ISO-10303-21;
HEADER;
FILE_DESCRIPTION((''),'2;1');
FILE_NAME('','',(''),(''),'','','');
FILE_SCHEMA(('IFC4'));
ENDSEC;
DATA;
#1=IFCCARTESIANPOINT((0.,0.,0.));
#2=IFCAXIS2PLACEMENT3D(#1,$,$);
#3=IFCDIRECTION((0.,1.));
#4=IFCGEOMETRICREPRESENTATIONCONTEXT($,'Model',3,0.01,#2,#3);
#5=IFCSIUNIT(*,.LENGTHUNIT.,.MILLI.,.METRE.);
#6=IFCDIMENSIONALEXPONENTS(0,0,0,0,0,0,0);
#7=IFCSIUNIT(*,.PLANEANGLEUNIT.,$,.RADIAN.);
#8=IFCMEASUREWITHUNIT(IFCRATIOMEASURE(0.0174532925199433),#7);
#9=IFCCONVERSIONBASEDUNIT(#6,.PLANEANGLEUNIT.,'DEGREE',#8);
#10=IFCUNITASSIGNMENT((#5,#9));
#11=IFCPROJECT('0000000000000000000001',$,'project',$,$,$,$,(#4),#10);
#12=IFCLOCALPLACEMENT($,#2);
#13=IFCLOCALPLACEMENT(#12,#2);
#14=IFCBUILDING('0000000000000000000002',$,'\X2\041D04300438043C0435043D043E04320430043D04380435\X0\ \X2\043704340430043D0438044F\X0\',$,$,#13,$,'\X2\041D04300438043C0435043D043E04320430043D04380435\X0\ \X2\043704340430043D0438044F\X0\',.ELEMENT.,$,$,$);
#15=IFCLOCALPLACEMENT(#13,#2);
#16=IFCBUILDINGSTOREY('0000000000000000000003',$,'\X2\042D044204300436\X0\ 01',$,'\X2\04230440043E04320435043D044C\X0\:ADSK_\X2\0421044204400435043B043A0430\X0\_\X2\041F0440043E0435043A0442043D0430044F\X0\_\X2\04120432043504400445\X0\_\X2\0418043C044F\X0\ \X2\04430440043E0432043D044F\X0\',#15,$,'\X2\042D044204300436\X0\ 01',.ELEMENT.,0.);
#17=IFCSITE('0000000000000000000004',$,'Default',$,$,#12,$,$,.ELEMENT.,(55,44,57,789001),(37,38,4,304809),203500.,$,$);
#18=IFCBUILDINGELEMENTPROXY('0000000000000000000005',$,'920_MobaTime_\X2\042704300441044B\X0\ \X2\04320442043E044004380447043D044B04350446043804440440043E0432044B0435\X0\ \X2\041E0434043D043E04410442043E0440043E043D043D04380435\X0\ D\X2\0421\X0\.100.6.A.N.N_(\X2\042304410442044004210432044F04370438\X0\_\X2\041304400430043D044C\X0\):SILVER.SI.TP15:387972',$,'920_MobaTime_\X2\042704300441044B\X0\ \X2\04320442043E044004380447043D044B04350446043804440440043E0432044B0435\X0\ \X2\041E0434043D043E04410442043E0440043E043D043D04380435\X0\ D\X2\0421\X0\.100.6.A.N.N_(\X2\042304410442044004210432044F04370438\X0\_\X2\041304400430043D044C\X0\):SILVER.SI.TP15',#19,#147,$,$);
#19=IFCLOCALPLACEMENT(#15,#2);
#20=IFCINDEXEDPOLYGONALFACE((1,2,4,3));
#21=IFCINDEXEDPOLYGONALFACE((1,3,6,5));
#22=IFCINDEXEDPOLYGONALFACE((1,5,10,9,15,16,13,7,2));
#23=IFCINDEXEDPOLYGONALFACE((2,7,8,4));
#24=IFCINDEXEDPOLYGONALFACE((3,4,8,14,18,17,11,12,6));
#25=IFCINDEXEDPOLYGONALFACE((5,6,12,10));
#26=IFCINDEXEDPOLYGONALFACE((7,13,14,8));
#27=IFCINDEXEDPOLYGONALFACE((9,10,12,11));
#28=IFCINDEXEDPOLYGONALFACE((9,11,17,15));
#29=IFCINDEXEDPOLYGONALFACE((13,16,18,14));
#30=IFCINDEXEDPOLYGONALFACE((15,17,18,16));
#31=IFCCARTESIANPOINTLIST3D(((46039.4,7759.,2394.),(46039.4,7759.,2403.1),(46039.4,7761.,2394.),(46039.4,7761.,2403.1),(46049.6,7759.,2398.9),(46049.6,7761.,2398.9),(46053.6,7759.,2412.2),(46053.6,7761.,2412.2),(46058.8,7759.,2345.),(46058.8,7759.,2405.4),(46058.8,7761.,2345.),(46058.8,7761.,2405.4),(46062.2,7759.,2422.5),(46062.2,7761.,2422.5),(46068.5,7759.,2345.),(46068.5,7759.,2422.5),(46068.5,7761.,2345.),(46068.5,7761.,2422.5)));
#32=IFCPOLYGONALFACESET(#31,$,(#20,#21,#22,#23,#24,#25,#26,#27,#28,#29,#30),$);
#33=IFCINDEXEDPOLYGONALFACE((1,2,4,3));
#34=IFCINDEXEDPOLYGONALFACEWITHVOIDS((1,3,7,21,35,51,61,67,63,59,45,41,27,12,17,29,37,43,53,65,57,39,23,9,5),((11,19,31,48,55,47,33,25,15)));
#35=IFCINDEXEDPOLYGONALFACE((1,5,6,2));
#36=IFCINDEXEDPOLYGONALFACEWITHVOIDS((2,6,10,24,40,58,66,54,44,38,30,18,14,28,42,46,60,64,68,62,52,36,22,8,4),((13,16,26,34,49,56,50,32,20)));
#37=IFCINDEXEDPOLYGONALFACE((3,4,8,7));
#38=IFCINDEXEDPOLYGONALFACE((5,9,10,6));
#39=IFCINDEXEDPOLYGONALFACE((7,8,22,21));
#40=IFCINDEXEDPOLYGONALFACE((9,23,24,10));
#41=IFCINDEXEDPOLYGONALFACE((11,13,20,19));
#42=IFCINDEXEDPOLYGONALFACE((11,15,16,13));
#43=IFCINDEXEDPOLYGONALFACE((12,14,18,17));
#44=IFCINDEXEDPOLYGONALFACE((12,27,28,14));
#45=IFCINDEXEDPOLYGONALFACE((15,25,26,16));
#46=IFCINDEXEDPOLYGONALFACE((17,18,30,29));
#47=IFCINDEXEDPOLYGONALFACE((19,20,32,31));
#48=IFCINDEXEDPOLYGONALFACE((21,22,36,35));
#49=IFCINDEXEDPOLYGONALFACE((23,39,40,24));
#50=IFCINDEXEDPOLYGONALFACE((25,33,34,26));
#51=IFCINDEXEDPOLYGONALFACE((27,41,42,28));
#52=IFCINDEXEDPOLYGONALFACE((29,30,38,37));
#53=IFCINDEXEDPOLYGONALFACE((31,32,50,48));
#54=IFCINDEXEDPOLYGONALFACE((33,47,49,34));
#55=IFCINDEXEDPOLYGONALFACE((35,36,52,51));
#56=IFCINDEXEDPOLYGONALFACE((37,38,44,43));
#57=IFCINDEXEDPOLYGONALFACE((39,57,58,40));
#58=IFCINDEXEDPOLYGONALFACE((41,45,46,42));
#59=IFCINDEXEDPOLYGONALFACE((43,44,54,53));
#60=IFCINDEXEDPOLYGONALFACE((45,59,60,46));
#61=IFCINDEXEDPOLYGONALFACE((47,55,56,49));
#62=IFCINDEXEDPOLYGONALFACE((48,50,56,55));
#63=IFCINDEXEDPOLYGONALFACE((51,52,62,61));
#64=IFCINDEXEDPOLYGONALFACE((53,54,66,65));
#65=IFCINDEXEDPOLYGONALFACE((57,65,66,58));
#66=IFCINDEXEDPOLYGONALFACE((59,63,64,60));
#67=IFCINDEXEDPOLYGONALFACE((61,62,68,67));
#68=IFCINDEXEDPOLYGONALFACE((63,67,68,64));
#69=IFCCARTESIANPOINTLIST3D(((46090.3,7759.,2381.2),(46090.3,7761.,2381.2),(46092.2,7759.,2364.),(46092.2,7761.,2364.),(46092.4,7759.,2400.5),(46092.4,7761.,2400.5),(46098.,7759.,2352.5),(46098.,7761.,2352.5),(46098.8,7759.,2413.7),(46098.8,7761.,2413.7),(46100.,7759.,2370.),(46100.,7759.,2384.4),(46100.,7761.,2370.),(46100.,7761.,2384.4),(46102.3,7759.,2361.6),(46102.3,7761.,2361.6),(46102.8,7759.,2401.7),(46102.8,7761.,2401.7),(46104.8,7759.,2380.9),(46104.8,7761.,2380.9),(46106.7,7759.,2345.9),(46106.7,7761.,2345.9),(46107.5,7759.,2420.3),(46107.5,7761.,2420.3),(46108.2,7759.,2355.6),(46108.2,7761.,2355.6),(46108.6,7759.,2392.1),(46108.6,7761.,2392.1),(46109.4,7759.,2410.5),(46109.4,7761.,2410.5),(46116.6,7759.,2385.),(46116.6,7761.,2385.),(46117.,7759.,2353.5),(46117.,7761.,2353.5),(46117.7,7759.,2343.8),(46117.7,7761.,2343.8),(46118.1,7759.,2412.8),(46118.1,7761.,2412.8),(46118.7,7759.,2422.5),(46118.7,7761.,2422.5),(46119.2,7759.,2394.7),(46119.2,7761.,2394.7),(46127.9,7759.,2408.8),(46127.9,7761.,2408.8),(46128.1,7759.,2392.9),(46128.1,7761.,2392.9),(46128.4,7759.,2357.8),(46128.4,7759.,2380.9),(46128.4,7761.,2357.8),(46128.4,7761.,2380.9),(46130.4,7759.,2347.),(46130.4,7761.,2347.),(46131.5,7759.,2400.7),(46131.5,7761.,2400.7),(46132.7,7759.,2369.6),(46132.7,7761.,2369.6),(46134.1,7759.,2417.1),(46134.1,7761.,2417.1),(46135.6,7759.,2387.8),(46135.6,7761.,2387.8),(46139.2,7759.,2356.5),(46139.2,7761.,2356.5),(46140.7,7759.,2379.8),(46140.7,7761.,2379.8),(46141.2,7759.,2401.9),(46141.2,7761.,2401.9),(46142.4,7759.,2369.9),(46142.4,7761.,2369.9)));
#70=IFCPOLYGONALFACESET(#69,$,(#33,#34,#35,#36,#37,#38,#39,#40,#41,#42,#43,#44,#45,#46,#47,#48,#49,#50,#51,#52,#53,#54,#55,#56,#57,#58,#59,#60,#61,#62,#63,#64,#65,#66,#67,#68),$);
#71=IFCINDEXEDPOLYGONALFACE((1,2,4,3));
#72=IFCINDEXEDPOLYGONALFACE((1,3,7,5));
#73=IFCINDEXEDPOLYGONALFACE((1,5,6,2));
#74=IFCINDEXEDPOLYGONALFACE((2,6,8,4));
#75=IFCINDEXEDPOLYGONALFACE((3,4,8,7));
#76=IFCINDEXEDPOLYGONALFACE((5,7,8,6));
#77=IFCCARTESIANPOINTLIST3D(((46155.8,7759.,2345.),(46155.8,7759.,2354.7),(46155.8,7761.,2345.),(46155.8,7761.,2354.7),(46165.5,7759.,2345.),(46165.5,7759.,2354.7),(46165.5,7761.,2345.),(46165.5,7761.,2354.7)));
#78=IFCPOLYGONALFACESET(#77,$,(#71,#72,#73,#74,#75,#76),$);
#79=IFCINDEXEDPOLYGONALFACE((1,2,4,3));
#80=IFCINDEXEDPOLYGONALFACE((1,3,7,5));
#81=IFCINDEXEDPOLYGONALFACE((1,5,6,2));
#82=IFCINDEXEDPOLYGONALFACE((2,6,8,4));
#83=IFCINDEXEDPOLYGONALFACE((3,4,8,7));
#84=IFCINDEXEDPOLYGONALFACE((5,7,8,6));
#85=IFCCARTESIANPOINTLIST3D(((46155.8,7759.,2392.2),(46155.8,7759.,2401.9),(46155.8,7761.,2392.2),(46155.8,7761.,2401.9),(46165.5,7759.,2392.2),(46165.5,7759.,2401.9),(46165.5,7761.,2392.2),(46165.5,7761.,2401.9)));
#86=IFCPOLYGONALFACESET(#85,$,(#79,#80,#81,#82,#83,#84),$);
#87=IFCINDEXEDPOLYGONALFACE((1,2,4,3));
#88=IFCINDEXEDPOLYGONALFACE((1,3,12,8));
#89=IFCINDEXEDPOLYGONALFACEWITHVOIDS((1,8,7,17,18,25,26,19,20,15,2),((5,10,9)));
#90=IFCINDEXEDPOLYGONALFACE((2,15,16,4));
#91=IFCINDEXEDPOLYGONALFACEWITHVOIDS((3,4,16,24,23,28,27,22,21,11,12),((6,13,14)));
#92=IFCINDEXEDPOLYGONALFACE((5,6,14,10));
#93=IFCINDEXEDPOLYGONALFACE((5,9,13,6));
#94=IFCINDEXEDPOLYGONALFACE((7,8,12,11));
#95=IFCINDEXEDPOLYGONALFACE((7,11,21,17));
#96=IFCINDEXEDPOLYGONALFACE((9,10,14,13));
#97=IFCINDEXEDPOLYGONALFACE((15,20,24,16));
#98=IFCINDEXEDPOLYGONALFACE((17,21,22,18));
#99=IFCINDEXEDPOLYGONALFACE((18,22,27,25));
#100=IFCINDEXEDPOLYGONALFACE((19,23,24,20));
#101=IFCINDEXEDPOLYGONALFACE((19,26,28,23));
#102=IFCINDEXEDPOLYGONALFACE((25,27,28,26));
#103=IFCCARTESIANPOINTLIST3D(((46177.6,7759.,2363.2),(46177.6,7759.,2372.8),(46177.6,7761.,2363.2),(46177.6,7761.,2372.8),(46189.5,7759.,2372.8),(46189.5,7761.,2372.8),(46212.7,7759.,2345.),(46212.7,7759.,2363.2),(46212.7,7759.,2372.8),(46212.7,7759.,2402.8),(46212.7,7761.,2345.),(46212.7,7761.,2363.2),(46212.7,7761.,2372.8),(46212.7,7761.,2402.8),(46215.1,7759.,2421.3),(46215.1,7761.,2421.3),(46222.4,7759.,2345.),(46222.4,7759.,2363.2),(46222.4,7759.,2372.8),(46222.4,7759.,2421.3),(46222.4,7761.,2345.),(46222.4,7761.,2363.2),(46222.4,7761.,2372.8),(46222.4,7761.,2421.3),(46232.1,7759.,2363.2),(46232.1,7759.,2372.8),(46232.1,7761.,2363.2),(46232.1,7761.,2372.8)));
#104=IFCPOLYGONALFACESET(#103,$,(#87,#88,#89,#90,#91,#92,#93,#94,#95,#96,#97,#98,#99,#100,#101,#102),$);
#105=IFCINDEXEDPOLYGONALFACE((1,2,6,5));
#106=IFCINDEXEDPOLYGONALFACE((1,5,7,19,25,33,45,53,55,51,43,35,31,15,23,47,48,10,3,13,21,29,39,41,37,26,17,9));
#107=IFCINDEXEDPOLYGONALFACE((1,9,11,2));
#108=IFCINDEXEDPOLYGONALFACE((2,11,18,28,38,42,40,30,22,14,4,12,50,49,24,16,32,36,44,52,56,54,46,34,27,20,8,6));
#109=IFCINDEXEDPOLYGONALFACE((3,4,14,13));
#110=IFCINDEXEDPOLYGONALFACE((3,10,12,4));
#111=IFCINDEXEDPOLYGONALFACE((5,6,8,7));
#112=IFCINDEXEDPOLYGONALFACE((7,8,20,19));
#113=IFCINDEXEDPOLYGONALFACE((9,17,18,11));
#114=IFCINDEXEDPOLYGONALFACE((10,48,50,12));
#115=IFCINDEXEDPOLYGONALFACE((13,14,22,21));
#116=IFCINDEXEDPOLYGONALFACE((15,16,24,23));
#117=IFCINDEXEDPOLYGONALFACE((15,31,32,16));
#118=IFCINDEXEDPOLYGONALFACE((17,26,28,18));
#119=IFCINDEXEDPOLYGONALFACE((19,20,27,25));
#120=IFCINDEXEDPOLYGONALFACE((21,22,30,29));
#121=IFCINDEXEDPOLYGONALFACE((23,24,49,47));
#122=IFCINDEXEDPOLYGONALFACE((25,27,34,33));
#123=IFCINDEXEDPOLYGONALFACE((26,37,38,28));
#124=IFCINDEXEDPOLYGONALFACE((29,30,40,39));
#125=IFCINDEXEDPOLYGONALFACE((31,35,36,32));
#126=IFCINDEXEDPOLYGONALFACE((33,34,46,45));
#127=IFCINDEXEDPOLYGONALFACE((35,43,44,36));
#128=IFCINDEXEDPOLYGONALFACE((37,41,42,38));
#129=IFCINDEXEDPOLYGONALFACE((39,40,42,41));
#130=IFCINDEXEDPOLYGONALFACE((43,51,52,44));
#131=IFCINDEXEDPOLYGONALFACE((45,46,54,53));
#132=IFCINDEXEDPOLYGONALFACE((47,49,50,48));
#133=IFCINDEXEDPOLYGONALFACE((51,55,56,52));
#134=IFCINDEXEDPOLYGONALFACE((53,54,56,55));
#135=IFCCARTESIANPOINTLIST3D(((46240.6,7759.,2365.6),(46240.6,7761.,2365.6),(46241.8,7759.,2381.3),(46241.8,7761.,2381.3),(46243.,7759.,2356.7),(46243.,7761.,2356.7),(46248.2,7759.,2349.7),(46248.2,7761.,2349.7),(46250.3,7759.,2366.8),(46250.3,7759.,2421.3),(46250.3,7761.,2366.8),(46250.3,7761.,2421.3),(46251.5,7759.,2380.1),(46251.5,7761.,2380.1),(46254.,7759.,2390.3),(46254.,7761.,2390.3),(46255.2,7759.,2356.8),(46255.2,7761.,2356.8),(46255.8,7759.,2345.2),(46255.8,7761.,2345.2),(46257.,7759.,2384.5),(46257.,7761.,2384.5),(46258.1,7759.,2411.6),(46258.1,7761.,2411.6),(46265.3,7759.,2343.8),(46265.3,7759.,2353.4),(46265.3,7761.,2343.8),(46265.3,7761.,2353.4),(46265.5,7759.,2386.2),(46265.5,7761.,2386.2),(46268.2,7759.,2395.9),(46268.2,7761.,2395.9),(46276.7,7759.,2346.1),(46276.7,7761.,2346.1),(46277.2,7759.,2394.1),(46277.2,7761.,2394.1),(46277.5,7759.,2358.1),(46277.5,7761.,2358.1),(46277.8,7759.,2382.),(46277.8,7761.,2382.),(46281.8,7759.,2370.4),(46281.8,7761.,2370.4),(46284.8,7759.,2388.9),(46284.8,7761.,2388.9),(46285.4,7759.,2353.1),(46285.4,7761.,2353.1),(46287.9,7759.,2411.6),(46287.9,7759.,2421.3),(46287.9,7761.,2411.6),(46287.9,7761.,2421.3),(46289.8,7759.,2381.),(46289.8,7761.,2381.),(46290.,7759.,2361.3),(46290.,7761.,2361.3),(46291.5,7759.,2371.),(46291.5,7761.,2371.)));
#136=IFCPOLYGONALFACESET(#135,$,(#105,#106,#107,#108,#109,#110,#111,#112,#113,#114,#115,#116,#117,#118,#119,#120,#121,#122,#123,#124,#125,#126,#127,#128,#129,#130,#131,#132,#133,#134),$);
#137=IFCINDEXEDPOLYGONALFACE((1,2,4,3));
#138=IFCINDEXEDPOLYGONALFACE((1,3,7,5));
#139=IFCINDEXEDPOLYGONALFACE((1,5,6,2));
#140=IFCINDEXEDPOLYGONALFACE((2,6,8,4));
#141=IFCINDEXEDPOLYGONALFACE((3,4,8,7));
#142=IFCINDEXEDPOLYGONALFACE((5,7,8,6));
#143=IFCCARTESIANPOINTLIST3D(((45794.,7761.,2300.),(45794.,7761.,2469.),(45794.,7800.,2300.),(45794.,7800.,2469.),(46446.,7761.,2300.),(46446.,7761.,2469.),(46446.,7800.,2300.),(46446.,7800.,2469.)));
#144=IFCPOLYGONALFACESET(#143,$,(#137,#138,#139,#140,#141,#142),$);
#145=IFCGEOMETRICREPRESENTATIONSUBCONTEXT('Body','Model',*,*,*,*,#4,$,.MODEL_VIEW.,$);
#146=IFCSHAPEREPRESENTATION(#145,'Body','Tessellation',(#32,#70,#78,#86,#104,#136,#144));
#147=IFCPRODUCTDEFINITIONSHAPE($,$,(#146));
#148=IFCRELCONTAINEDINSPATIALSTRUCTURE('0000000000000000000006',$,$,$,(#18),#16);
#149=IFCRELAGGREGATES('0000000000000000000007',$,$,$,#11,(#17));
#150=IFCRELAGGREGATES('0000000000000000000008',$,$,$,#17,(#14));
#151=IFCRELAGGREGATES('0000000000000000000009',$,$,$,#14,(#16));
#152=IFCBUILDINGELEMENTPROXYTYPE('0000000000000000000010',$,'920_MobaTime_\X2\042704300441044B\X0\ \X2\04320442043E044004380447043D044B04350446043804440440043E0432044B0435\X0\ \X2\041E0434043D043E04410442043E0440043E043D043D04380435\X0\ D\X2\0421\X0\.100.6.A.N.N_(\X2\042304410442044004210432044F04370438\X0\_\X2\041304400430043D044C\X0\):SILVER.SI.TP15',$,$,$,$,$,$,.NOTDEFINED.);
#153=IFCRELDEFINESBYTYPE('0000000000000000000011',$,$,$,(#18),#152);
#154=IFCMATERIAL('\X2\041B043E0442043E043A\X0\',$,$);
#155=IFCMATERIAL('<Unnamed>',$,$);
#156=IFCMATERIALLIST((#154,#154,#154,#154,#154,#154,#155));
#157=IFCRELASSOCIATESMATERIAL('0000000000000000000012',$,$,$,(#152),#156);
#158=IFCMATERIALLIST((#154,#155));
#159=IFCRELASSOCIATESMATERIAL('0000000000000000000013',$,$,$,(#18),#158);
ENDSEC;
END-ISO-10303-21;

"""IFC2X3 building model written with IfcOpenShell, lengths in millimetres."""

from ifc_helpers import new_model, entity, si_unit, converted_unit, direction, frame, origin, origin_2d_with_axis, place, context, subcontext, project, spatial, polyline, rectangle, outline, extrude, source, transform, mapped, material, material_list, type_object, type_shapes, element, save


model = new_model("IFC2X3")

# Units and contexts
model_context = context("Model", 3, precision=0.01, world=origin(), true_north=direction((0.0, 1.0)))
body_context = subcontext(model_context, "Body", "Model", "MODEL_VIEW")
ifc_project = project(units=[si_unit("LENGTHUNIT", "METRE", prefix="MILLI"), converted_unit("PLANEANGLEUNIT", "DEGREE", entity("IfcRatioMeasure", 0.0174532925199433), si_unit("PLANEANGLEUNIT", "RADIAN"), dimensions=[0, 0, 0, 0, 0, 0, 0])], contexts=[model_context])

# Site, building, storey
site_placement = place(None, origin())
site = spatial("IfcSite", under=ifc_project, at=site_placement, Name="Default", CompositionType="ELEMENT", RefLatitude=(55, 44, 57, 789001), RefLongitude=(37, 38, 4, 304809), RefElevation=203500.0)
building_placement = place(site_placement, origin())
building = spatial("IfcBuilding", under=site, at=building_placement, Name="Наименование здания", LongName="Наименование здания", CompositionType="ELEMENT")
storey_placement = place(building_placement, origin())
storey = spatial("IfcBuildingStorey", under=building, at=storey_placement, Name="Этаж 01", ObjectType="Уровень:ADSK_Стрелка_Проектная_Вверх_Имя уровня", LongName="Этаж 01", CompositionType="ELEMENT", Elevation=0.0)

# Building element proxy
ifc_material_1 = material(Name="Лоток")
ifc_material_2 = material(Name="<Unnamed>")
ifc_material_list_1 = material_list([ifc_material_1, ifc_material_1, ifc_material_1, ifc_material_1, ifc_material_1, ifc_material_1, ifc_material_2])
building_element_proxy_type = type_object("IfcBuildingElementProxyType", Name="920_MobaTime_Часы вторичныецифровые Односторонние DС.100.6.A.N.N_(УстрСвязи_Грань):SILVER.SI.TP15", PredefinedType="NOTDEFINED", material=ifc_material_list_1)
shared_shape = source(origin(), body_context, "Body", "SweptSolid", [
    extrude(outline(polyline([(-49.3, -13.1), (28.2, -13.1), (28.2, -6.8), (17.9, 1.8), (8.8, 16.0), (-0.3, 16.0), (4.6, 5.8), (11.1, -3.4), (-49.3, -3.4), (-49.3, -13.1)])), frame((-64.6, 9.8, 39.0), z_axis=(0.0, 0.0, 1.0), x_axis=(0.0, 1.0, 0.0)), (0.0, 0.0, 1.0), 2.0),
    extrude(outline(polyline([(2.2, -27.6), (19.0, -27.6), (30.5, -16.1), (33.3, -4.9), (31.0, 5.8), (21.8, 17.2), (5.2, 27.3), (-11.1, 33.0), (-24.0, 32.7), (-33.6, 27.6), (-40.3, 18.6), (-42.8, 5.7), (-38.0, -6.3), (-27.2, -14.9), (-17.5, -17.7), (-8.2, -16.4), (-0.3, -11.9), (5.1, -4.5), (7.3, 6.2), (4.0, 17.2), (18.4, 7.3), (23.6, -2.4), (22.0, -11.4), (14.2, -18.4), (5.3, -18.3), (2.2, -27.6)]), holes=[polyline([(-9.0, 23.3), (-1.3, 14.3), (-2.5, 2.0), (-11.4, -7.0), (-23.4, -6.0), (-32.2, 2.9), (-31.2, 15.1), (-25.6, 22.1), (-17.5, 24.9), (-9.0, 23.3)])]), frame((-2.7, 3.6, 39.0), z_axis=(0.0, 0.0, 1.0), x_axis=(-0.427649, 0.903945, 0.0)), (0.0, 0.0, 1.0), 2.0),
    extrude(rectangle(XDim=9.7, YDim=9.7, at=origin_2d_with_axis()), frame((40.6, -34.7, 39.0)), (0.0, 0.0, 1.0), 2.0),
    extrude(rectangle(XDim=9.7, YDim=9.7, at=origin_2d_with_axis()), frame((40.6, 12.6, 39.0)), (0.0, 0.0, 1.0), 2.0),
    extrude(outline(polyline([(-0.9, -28.1), (8.8, -28.1), (8.8, -9.9), (18.5, -9.9), (18.5, -0.2), (8.8, -0.2), (8.8, 48.3), (1.5, 48.3), (-36.0, -0.2), (-36.0, -9.9), (-0.9, -9.9), (-0.9, -28.1)]), holes=[polyline([(-0.9, -0.2), (-24.1, -0.2), (-0.9, 29.7), (-0.9, -0.2)])]), frame((93.6, -11.4, 39.0)), (0.0, 0.0, 1.0), 2.0),
    extrude(outline(polyline([(3.3, -28.3), (12.5, -28.3), (20.5, -25.0), (26.8, -18.9), (30.7, -10.0), (31.4, 1.6), (26.9, 11.8), (20.1, 18.4), (11.1, 22.3), (1.0, 23.3), (-7.9, 20.4), (-14.9, 14.5), (-18.9, 6.2), (-17.1, -9.0), (-36.7, 0.5), (-29.1, 29.2), (-38.5, 31.7), (-48.1, -4.6), (-11.6, -23.1), (-8.0, -14.0), (-10.8, -7.6), (-10.2, 1.1), (-3.0, 11.8), (9.2, 12.8), (20.0, 5.5), (21.4, -7.5), (15.5, -16.4), (4.6, -18.6), (3.3, -28.3)])), frame((147.1, -8.5, 39.0), z_axis=(0.0, 0.0, 1.0), x_axis=(0.256974, -0.966418, 0.0)), (0.0, 0.0, 1.0), 2.0),
    extrude(rectangle(XDim=652.0, YDim=169.0, at=origin_2d_with_axis()), frame((0.0, 0.0, 0.0), z_axis=(0.0, 0.0, 1.0), x_axis=(-1.0, 0.0, 0.0)), (0.0, 0.0, 1.0), 39.0),
])
type_shapes(building_element_proxy_type, [shared_shape])
ifc_material_list_2 = material_list([ifc_material_1, ifc_material_2])
for number, where, z_axis, x_axis, name in (
    (1, (46120.0, 7800.0, 2384.5), (0.0, -1.0, 0.0), (1.0, 0.0, 0.0), "920_MobaTime_Часы вторичныецифровые Односторонние DС.100.6.A.N.N_(УстрСвязи_Грань):SILVER.SI.TP15:387972"),
):
    element("IfcBuildingElementProxy", number, at=place(storey_placement, frame(where, z_axis=z_axis, x_axis=x_axis)), inside=storey, type_object=building_element_proxy_type, material=ifc_material_list_2, Name=name, ObjectType="920_MobaTime_Часы вторичныецифровые Односторонние DС.100.6.A.N.N_(УстрСвязи_Грань):SILVER.SI.TP15", context=body_context, shape_type="MappedRepresentation", body=[
        mapped(shared_shape, transform((0.0, 0.0, 0.0), scale=1.0)),
    ])

save(model, "model.ifc")
